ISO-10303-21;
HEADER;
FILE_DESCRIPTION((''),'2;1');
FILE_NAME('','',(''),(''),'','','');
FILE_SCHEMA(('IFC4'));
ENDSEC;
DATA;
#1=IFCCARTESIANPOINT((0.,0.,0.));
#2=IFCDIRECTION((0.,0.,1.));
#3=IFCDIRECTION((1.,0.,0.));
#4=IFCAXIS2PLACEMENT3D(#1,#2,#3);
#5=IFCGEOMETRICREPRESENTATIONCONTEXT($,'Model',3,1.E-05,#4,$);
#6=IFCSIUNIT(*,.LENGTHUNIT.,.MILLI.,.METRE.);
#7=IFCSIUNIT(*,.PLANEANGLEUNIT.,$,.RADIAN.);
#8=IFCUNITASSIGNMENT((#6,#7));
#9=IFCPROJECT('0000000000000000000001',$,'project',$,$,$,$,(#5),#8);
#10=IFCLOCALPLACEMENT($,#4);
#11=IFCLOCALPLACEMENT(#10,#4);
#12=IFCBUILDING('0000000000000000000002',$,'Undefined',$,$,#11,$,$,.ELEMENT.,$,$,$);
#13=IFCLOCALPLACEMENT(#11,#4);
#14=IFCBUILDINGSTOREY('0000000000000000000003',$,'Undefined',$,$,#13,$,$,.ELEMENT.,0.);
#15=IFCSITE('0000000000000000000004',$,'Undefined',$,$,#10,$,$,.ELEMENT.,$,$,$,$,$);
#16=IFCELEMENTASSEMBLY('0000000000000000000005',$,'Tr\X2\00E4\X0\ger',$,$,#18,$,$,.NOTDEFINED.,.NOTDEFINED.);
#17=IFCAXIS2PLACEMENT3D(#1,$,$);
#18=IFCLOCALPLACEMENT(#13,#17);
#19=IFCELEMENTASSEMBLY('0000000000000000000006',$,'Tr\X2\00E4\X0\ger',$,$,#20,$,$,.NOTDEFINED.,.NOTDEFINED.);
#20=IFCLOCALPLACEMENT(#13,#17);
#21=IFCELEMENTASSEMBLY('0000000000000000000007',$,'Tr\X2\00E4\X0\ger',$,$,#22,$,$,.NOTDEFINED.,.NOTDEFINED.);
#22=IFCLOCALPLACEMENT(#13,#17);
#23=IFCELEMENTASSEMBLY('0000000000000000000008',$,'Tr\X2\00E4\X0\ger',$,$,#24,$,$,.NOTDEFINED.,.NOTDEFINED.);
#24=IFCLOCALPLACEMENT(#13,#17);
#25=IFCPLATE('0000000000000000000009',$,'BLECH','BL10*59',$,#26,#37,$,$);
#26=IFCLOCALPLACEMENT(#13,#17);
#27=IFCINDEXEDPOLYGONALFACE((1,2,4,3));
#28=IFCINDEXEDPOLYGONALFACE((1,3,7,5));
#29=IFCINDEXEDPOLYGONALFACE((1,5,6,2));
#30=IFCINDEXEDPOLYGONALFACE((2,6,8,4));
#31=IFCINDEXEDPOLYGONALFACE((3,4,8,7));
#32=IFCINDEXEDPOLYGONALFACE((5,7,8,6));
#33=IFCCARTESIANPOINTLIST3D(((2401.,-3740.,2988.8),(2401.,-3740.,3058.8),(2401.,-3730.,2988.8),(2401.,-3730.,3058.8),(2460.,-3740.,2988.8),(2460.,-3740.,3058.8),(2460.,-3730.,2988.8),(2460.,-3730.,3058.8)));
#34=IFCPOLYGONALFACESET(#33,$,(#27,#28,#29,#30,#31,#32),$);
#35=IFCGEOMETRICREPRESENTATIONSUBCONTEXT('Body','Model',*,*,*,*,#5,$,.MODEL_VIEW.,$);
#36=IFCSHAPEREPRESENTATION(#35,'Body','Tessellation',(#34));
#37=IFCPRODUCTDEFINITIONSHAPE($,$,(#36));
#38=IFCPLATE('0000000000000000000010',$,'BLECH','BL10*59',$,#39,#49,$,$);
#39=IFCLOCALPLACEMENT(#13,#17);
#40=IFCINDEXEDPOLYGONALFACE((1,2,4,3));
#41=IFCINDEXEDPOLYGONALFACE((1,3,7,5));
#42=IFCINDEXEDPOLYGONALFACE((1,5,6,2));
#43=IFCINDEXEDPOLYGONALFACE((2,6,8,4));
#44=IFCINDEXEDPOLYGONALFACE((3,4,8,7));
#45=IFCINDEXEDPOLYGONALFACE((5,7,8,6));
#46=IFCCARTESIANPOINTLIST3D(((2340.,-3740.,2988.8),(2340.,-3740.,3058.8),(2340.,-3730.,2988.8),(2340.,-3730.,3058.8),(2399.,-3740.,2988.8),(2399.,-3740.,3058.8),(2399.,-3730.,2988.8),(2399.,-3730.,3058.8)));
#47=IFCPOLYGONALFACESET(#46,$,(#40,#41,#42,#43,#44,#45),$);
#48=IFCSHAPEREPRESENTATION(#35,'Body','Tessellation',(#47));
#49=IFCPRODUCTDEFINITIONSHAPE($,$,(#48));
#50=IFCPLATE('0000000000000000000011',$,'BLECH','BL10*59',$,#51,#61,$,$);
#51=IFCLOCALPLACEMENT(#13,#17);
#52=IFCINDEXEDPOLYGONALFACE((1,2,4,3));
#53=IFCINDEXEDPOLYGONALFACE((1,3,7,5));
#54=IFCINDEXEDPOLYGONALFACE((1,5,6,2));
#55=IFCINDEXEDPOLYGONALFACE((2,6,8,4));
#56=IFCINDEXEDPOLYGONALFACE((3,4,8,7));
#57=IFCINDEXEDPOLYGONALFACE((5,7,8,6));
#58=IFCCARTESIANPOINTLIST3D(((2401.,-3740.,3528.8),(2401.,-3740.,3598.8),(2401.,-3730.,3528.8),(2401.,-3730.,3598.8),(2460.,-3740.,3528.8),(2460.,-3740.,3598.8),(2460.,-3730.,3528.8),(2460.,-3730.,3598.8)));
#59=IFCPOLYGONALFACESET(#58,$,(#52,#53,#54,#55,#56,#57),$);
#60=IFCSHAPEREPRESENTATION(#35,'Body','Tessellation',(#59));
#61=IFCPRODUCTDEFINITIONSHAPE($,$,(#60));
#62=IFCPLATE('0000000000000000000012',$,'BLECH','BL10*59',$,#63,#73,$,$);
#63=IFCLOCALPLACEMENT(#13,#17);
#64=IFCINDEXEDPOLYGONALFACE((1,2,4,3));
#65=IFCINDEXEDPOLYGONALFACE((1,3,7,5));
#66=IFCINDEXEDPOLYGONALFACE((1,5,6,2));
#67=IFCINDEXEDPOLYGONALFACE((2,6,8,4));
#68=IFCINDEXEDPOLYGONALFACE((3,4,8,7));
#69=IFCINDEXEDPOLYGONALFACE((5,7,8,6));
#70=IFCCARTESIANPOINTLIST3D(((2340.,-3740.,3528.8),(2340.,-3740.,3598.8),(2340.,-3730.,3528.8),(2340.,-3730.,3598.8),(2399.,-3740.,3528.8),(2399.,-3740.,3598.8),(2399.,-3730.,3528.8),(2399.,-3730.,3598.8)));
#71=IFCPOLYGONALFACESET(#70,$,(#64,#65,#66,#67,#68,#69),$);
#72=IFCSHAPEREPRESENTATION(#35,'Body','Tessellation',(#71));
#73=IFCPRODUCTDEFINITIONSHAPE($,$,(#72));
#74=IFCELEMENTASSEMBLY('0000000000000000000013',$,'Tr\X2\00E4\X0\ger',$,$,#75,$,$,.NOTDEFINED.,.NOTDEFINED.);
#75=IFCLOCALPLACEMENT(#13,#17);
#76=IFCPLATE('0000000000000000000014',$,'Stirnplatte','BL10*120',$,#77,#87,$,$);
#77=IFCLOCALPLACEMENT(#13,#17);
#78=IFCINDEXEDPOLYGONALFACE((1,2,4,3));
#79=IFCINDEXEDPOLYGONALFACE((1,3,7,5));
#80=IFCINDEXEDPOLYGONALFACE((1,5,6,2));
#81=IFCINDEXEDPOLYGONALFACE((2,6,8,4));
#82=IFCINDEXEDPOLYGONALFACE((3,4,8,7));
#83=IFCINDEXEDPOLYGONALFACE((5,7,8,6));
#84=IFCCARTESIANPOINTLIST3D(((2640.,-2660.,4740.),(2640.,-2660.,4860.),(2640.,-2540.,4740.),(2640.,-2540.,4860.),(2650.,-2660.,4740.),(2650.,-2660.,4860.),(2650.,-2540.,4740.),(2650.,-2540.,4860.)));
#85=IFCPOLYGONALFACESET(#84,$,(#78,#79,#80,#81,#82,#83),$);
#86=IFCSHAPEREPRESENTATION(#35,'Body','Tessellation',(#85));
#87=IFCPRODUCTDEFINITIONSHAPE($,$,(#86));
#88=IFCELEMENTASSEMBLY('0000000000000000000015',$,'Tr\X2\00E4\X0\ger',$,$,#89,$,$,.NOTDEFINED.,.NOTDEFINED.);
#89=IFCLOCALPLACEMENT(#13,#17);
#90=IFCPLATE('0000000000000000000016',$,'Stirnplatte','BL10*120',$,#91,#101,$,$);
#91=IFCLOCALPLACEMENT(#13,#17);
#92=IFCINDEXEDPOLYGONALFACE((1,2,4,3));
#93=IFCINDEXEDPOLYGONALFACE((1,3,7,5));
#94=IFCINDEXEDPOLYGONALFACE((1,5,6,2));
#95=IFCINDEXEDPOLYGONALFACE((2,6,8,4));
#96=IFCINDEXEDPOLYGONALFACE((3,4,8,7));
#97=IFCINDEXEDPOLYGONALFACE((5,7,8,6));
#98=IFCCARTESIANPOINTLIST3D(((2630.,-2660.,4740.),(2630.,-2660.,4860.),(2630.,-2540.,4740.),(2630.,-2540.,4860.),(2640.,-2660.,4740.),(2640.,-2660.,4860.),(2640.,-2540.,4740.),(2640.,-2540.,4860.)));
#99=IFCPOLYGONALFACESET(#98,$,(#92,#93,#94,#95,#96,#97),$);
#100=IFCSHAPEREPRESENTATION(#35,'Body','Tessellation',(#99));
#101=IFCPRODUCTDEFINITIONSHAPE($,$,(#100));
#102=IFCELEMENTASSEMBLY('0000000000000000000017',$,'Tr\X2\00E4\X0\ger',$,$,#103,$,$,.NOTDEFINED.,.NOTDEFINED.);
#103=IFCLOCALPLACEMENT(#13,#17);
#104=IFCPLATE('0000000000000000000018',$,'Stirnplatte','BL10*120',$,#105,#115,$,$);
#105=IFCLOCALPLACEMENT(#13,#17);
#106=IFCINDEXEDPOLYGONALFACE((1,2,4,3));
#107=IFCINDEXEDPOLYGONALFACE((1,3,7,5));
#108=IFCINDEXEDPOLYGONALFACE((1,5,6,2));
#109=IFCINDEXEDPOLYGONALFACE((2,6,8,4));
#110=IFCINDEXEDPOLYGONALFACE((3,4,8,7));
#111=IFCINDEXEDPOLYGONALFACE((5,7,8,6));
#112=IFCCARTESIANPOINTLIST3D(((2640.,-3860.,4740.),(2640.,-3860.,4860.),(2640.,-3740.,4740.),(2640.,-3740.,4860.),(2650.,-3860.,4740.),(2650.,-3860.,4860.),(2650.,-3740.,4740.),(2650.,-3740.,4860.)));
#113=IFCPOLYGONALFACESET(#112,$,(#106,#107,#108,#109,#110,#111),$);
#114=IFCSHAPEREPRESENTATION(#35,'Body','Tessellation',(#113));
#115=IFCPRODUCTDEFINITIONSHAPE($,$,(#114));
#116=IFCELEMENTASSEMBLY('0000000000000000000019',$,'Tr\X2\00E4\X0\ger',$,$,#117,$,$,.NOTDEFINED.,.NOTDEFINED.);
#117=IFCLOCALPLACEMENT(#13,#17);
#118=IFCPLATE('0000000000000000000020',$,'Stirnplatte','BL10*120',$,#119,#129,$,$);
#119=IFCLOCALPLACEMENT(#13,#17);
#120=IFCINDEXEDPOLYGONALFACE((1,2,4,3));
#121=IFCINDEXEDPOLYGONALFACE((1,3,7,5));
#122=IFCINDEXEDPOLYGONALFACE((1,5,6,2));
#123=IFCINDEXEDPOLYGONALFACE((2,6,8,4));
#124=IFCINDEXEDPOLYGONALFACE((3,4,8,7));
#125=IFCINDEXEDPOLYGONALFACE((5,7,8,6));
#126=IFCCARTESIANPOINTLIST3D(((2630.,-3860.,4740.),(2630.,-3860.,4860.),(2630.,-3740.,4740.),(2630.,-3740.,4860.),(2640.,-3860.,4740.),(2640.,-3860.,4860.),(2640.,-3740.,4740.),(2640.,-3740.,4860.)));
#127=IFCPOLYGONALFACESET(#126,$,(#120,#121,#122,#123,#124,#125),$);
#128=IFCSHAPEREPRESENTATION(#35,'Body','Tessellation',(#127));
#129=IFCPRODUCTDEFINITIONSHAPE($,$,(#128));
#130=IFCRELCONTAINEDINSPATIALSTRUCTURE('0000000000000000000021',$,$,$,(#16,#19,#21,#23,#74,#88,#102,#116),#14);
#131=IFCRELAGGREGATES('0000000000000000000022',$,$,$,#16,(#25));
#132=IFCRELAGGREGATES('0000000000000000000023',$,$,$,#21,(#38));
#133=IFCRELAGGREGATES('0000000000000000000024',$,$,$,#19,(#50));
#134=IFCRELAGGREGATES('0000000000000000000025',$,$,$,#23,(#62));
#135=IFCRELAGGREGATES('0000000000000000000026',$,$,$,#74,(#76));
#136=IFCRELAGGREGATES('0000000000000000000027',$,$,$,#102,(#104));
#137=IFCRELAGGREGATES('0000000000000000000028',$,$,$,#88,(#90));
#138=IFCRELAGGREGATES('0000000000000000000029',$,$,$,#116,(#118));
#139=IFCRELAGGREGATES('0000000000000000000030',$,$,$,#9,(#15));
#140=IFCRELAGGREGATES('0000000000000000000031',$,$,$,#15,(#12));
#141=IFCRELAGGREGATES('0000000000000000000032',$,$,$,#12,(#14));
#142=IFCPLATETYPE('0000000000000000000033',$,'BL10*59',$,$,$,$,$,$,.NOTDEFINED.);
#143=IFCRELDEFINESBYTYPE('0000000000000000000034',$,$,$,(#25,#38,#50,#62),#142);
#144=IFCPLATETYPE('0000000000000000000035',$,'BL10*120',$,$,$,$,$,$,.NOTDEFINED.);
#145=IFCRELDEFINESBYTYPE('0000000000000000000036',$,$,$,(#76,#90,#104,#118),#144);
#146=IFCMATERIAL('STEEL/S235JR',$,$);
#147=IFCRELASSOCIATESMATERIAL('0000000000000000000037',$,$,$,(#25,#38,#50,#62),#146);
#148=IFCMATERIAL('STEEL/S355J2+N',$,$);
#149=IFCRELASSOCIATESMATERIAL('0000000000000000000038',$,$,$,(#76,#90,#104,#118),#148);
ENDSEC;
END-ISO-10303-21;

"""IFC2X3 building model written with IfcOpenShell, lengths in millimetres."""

from ifc_helpers import new_model, si_unit, frame, origin_with_axes, place, context, subcontext, project, spatial, polyline, outline, extrude, material, type_object, element, aggregate, save


model = new_model("IFC2X3")

# Units and contexts
model_context = context("Model", 3, precision=1e-05, world=origin_with_axes())
body_context = subcontext(model_context, "Body", "Model", "MODEL_VIEW")
ifc_project = project(units=[si_unit("LENGTHUNIT", "METRE", prefix="MILLI"), si_unit("PLANEANGLEUNIT", "RADIAN")], contexts=[model_context])

# Site, building, storey
site_placement = place(None, origin_with_axes())
site = spatial("IfcSite", under=ifc_project, at=site_placement, Name="Undefined", CompositionType="ELEMENT")
building_placement = place(site_placement, origin_with_axes())
building = spatial("IfcBuilding", under=site, at=building_placement, Name="Undefined", CompositionType="ELEMENT")
storey_placement = place(building_placement, origin_with_axes())
storey = spatial("IfcBuildingStorey", under=building, at=storey_placement, Name="Undefined", CompositionType="ELEMENT", Elevation=0.0)

# Shared definitions
ifc_material_1 = material(Name="STEEL/S235JR")

# Element assemblies
assembly_1_placement = place(storey_placement, origin_with_axes())
assembly_1 = element("IfcElementAssembly", 1, at=assembly_1_placement, inside=storey, Name="Träger", AssemblyPlace="NOTDEFINED", PredefinedType="NOTDEFINED")
assembly_2_placement = place(storey_placement, origin_with_axes())
assembly_2 = element("IfcElementAssembly", 2, at=assembly_2_placement, inside=storey, Name="Träger", AssemblyPlace="NOTDEFINED", PredefinedType="NOTDEFINED")

# Element assemblies
assembly_3_placement = place(storey_placement, origin_with_axes())
assembly_3 = element("IfcElementAssembly", 3, at=assembly_3_placement, inside=storey, Name="Träger", AssemblyPlace="NOTDEFINED", PredefinedType="NOTDEFINED")
assembly_4_placement = place(storey_placement, origin_with_axes())
assembly_4 = element("IfcElementAssembly", 4, at=assembly_4_placement, inside=storey, Name="Träger", AssemblyPlace="NOTDEFINED", PredefinedType="NOTDEFINED")

# Plates
plate_type_1 = type_object("IfcPlateType", Name="BL10*59", PredefinedType="NOTDEFINED")
plate_1_placement = place(assembly_1_placement, frame((2401.0, -3735.0, 3058.8), z_axis=(0.0, 1.0, 0.0), x_axis=(1.0, 0.0, 0.0)))
plate_1 = element("IfcPlate", 5, at=plate_1_placement, type_object=plate_type_1, material=ifc_material_1, Name="BLECH", Description="BL10*59", context=body_context, shape_type="SweptSolid", body=[
    extrude(outline(polyline([(0.0, 0.0), (59.0, 0.0), (59.0, 70.0), (0.0, 70.0), (0.0, 0.0)])), frame((0.0, 0.0, -5.0), z_axis=(0.0, 0.0, 1.0), x_axis=(1.0, 0.0, 0.0)), (0.0, 0.0, 1.0), 10.0),
])
aggregate(assembly_1, [plate_1])
plate_2_placement = place(assembly_3_placement, frame((2399.0, -3735.0, 3058.8), z_axis=(0.0, -1.0, 0.0), x_axis=(-1.0, 0.0, 0.0)))
plate_2 = element("IfcPlate", 6, at=plate_2_placement, type_object=plate_type_1, material=ifc_material_1, Name="BLECH", Description="BL10*59", context=body_context, shape_type="SweptSolid", body=[
    extrude(outline(polyline([(0.0, 0.0), (59.0, 0.0), (59.0, 70.0), (0.0, 70.0), (0.0, 0.0)])), frame((0.0, 0.0, -5.0), z_axis=(0.0, 0.0, 1.0), x_axis=(1.0, 0.0, 0.0)), (0.0, 0.0, 1.0), 10.0),
])
aggregate(assembly_3, [plate_2])
plate_3_placement = place(assembly_2_placement, frame((2401.0, -3735.0, 3598.8), z_axis=(0.0, 1.0, 0.0), x_axis=(1.0, 0.0, 0.0)))
plate_3 = element("IfcPlate", 7, at=plate_3_placement, type_object=plate_type_1, material=ifc_material_1, Name="BLECH", Description="BL10*59", context=body_context, shape_type="SweptSolid", body=[
    extrude(outline(polyline([(0.0, 0.0), (59.0, 0.0), (59.0, 70.0), (0.0, 70.0), (0.0, 0.0)])), frame((0.0, 0.0, -5.0), z_axis=(0.0, 0.0, 1.0), x_axis=(1.0, 0.0, 0.0)), (0.0, 0.0, 1.0), 10.0),
])
aggregate(assembly_2, [plate_3])
plate_4_placement = place(assembly_4_placement, frame((2399.0, -3735.0, 3598.8), z_axis=(0.0, -1.0, 0.0), x_axis=(-1.0, 0.0, 0.0)))
plate_4 = element("IfcPlate", 8, at=plate_4_placement, type_object=plate_type_1, material=ifc_material_1, Name="BLECH", Description="BL10*59", context=body_context, shape_type="SweptSolid", body=[
    extrude(outline(polyline([(0.0, 0.0), (59.0, 0.0), (59.0, 70.0), (0.0, 70.0), (0.0, 0.0)])), frame((0.0, 0.0, -5.0), z_axis=(0.0, 0.0, 1.0), x_axis=(1.0, 0.0, 0.0)), (0.0, 0.0, 1.0), 10.0),
])
aggregate(assembly_4, [plate_4])

# Element assemblies, plates
assembly_5_placement = place(storey_placement, origin_with_axes())
assembly_5 = element("IfcElementAssembly", 9, at=assembly_5_placement, inside=storey, Name="Träger", AssemblyPlace="NOTDEFINED", PredefinedType="NOTDEFINED")
ifc_material_2 = material(Name="STEEL/S355J2+N")
plate_type_2 = type_object("IfcPlateType", Name="BL10*120", PredefinedType="NOTDEFINED")
plate_5_placement = place(assembly_5_placement, frame((2645.0, -2600.0, 4740.0), z_axis=(1.0, 0.0, 0.0), x_axis=(0.0, 0.0, 1.0)))
plate_5 = element("IfcPlate", 10, at=plate_5_placement, type_object=plate_type_2, material=ifc_material_2, Name="Stirnplatte", Description="BL10*120", context=body_context, shape_type="SweptSolid", body=[
    extrude(outline(polyline([(0.0, -60.0), (0.0, 60.0), (120.0, 60.0), (120.0, -60.0), (0.0, -60.0)])), frame((0.0, 0.0, -5.0), z_axis=(0.0, 0.0, 1.0), x_axis=(1.0, 0.0, 0.0)), (0.0, 0.0, 1.0), 10.0),
])
aggregate(assembly_5, [plate_5])
assembly_6_placement = place(storey_placement, origin_with_axes())
assembly_6 = element("IfcElementAssembly", 11, at=assembly_6_placement, inside=storey, Name="Träger", AssemblyPlace="NOTDEFINED", PredefinedType="NOTDEFINED")
plate_6_placement = place(assembly_6_placement, frame((2635.0, -2600.0, 4740.0), z_axis=(1.0, 0.0, 0.0), x_axis=(0.0, 0.0, 1.0)))
plate_6 = element("IfcPlate", 12, at=plate_6_placement, type_object=plate_type_2, material=ifc_material_2, Name="Stirnplatte", Description="BL10*120", context=body_context, shape_type="SweptSolid", body=[
    extrude(outline(polyline([(0.0, -60.0), (0.0, 60.0), (120.0, 60.0), (120.0, -60.0), (0.0, -60.0)])), frame((0.0, 0.0, -5.0), z_axis=(0.0, 0.0, 1.0), x_axis=(1.0, 0.0, 0.0)), (0.0, 0.0, 1.0), 10.0),
])
assembly_7_placement = place(storey_placement, origin_with_axes())
assembly_7 = element("IfcElementAssembly", 13, at=assembly_7_placement, inside=storey, Name="Träger", AssemblyPlace="NOTDEFINED", PredefinedType="NOTDEFINED")
plate_7_placement = place(assembly_7_placement, frame((2645.0, -3800.0, 4740.0), z_axis=(1.0, 0.0, 0.0), x_axis=(0.0, 0.0, 1.0)))
plate_7 = element("IfcPlate", 14, at=plate_7_placement, type_object=plate_type_2, material=ifc_material_2, Name="Stirnplatte", Description="BL10*120", context=body_context, shape_type="SweptSolid", body=[
    extrude(outline(polyline([(0.0, -60.0), (0.0, 60.0), (120.0, 60.0), (120.0, -60.0), (0.0, -60.0)])), frame((0.0, 0.0, -5.0), z_axis=(0.0, 0.0, 1.0), x_axis=(1.0, 0.0, 0.0)), (0.0, 0.0, 1.0), 10.0),
])
aggregate(assembly_7, [plate_7])
assembly_8_placement = place(storey_placement, origin_with_axes())
assembly_8 = element("IfcElementAssembly", 15, at=assembly_8_placement, inside=storey, Name="Träger", AssemblyPlace="NOTDEFINED", PredefinedType="NOTDEFINED")
plate_8_placement = place(assembly_8_placement, frame((2635.0, -3800.0, 4740.0), z_axis=(1.0, 0.0, 0.0), x_axis=(0.0, 0.0, 1.0)))
plate_8 = element("IfcPlate", 16, at=plate_8_placement, type_object=plate_type_2, material=ifc_material_2, Name="Stirnplatte", Description="BL10*120", context=body_context, shape_type="SweptSolid", body=[
    extrude(outline(polyline([(0.0, -60.0), (0.0, 60.0), (120.0, 60.0), (120.0, -60.0), (0.0, -60.0)])), frame((0.0, 0.0, -5.0), z_axis=(0.0, 0.0, 1.0), x_axis=(1.0, 0.0, 0.0)), (0.0, 0.0, 1.0), 10.0),
])

aggregate(assembly_6, [plate_6])
aggregate(assembly_8, [plate_8])

save(model, "model.ifc")
